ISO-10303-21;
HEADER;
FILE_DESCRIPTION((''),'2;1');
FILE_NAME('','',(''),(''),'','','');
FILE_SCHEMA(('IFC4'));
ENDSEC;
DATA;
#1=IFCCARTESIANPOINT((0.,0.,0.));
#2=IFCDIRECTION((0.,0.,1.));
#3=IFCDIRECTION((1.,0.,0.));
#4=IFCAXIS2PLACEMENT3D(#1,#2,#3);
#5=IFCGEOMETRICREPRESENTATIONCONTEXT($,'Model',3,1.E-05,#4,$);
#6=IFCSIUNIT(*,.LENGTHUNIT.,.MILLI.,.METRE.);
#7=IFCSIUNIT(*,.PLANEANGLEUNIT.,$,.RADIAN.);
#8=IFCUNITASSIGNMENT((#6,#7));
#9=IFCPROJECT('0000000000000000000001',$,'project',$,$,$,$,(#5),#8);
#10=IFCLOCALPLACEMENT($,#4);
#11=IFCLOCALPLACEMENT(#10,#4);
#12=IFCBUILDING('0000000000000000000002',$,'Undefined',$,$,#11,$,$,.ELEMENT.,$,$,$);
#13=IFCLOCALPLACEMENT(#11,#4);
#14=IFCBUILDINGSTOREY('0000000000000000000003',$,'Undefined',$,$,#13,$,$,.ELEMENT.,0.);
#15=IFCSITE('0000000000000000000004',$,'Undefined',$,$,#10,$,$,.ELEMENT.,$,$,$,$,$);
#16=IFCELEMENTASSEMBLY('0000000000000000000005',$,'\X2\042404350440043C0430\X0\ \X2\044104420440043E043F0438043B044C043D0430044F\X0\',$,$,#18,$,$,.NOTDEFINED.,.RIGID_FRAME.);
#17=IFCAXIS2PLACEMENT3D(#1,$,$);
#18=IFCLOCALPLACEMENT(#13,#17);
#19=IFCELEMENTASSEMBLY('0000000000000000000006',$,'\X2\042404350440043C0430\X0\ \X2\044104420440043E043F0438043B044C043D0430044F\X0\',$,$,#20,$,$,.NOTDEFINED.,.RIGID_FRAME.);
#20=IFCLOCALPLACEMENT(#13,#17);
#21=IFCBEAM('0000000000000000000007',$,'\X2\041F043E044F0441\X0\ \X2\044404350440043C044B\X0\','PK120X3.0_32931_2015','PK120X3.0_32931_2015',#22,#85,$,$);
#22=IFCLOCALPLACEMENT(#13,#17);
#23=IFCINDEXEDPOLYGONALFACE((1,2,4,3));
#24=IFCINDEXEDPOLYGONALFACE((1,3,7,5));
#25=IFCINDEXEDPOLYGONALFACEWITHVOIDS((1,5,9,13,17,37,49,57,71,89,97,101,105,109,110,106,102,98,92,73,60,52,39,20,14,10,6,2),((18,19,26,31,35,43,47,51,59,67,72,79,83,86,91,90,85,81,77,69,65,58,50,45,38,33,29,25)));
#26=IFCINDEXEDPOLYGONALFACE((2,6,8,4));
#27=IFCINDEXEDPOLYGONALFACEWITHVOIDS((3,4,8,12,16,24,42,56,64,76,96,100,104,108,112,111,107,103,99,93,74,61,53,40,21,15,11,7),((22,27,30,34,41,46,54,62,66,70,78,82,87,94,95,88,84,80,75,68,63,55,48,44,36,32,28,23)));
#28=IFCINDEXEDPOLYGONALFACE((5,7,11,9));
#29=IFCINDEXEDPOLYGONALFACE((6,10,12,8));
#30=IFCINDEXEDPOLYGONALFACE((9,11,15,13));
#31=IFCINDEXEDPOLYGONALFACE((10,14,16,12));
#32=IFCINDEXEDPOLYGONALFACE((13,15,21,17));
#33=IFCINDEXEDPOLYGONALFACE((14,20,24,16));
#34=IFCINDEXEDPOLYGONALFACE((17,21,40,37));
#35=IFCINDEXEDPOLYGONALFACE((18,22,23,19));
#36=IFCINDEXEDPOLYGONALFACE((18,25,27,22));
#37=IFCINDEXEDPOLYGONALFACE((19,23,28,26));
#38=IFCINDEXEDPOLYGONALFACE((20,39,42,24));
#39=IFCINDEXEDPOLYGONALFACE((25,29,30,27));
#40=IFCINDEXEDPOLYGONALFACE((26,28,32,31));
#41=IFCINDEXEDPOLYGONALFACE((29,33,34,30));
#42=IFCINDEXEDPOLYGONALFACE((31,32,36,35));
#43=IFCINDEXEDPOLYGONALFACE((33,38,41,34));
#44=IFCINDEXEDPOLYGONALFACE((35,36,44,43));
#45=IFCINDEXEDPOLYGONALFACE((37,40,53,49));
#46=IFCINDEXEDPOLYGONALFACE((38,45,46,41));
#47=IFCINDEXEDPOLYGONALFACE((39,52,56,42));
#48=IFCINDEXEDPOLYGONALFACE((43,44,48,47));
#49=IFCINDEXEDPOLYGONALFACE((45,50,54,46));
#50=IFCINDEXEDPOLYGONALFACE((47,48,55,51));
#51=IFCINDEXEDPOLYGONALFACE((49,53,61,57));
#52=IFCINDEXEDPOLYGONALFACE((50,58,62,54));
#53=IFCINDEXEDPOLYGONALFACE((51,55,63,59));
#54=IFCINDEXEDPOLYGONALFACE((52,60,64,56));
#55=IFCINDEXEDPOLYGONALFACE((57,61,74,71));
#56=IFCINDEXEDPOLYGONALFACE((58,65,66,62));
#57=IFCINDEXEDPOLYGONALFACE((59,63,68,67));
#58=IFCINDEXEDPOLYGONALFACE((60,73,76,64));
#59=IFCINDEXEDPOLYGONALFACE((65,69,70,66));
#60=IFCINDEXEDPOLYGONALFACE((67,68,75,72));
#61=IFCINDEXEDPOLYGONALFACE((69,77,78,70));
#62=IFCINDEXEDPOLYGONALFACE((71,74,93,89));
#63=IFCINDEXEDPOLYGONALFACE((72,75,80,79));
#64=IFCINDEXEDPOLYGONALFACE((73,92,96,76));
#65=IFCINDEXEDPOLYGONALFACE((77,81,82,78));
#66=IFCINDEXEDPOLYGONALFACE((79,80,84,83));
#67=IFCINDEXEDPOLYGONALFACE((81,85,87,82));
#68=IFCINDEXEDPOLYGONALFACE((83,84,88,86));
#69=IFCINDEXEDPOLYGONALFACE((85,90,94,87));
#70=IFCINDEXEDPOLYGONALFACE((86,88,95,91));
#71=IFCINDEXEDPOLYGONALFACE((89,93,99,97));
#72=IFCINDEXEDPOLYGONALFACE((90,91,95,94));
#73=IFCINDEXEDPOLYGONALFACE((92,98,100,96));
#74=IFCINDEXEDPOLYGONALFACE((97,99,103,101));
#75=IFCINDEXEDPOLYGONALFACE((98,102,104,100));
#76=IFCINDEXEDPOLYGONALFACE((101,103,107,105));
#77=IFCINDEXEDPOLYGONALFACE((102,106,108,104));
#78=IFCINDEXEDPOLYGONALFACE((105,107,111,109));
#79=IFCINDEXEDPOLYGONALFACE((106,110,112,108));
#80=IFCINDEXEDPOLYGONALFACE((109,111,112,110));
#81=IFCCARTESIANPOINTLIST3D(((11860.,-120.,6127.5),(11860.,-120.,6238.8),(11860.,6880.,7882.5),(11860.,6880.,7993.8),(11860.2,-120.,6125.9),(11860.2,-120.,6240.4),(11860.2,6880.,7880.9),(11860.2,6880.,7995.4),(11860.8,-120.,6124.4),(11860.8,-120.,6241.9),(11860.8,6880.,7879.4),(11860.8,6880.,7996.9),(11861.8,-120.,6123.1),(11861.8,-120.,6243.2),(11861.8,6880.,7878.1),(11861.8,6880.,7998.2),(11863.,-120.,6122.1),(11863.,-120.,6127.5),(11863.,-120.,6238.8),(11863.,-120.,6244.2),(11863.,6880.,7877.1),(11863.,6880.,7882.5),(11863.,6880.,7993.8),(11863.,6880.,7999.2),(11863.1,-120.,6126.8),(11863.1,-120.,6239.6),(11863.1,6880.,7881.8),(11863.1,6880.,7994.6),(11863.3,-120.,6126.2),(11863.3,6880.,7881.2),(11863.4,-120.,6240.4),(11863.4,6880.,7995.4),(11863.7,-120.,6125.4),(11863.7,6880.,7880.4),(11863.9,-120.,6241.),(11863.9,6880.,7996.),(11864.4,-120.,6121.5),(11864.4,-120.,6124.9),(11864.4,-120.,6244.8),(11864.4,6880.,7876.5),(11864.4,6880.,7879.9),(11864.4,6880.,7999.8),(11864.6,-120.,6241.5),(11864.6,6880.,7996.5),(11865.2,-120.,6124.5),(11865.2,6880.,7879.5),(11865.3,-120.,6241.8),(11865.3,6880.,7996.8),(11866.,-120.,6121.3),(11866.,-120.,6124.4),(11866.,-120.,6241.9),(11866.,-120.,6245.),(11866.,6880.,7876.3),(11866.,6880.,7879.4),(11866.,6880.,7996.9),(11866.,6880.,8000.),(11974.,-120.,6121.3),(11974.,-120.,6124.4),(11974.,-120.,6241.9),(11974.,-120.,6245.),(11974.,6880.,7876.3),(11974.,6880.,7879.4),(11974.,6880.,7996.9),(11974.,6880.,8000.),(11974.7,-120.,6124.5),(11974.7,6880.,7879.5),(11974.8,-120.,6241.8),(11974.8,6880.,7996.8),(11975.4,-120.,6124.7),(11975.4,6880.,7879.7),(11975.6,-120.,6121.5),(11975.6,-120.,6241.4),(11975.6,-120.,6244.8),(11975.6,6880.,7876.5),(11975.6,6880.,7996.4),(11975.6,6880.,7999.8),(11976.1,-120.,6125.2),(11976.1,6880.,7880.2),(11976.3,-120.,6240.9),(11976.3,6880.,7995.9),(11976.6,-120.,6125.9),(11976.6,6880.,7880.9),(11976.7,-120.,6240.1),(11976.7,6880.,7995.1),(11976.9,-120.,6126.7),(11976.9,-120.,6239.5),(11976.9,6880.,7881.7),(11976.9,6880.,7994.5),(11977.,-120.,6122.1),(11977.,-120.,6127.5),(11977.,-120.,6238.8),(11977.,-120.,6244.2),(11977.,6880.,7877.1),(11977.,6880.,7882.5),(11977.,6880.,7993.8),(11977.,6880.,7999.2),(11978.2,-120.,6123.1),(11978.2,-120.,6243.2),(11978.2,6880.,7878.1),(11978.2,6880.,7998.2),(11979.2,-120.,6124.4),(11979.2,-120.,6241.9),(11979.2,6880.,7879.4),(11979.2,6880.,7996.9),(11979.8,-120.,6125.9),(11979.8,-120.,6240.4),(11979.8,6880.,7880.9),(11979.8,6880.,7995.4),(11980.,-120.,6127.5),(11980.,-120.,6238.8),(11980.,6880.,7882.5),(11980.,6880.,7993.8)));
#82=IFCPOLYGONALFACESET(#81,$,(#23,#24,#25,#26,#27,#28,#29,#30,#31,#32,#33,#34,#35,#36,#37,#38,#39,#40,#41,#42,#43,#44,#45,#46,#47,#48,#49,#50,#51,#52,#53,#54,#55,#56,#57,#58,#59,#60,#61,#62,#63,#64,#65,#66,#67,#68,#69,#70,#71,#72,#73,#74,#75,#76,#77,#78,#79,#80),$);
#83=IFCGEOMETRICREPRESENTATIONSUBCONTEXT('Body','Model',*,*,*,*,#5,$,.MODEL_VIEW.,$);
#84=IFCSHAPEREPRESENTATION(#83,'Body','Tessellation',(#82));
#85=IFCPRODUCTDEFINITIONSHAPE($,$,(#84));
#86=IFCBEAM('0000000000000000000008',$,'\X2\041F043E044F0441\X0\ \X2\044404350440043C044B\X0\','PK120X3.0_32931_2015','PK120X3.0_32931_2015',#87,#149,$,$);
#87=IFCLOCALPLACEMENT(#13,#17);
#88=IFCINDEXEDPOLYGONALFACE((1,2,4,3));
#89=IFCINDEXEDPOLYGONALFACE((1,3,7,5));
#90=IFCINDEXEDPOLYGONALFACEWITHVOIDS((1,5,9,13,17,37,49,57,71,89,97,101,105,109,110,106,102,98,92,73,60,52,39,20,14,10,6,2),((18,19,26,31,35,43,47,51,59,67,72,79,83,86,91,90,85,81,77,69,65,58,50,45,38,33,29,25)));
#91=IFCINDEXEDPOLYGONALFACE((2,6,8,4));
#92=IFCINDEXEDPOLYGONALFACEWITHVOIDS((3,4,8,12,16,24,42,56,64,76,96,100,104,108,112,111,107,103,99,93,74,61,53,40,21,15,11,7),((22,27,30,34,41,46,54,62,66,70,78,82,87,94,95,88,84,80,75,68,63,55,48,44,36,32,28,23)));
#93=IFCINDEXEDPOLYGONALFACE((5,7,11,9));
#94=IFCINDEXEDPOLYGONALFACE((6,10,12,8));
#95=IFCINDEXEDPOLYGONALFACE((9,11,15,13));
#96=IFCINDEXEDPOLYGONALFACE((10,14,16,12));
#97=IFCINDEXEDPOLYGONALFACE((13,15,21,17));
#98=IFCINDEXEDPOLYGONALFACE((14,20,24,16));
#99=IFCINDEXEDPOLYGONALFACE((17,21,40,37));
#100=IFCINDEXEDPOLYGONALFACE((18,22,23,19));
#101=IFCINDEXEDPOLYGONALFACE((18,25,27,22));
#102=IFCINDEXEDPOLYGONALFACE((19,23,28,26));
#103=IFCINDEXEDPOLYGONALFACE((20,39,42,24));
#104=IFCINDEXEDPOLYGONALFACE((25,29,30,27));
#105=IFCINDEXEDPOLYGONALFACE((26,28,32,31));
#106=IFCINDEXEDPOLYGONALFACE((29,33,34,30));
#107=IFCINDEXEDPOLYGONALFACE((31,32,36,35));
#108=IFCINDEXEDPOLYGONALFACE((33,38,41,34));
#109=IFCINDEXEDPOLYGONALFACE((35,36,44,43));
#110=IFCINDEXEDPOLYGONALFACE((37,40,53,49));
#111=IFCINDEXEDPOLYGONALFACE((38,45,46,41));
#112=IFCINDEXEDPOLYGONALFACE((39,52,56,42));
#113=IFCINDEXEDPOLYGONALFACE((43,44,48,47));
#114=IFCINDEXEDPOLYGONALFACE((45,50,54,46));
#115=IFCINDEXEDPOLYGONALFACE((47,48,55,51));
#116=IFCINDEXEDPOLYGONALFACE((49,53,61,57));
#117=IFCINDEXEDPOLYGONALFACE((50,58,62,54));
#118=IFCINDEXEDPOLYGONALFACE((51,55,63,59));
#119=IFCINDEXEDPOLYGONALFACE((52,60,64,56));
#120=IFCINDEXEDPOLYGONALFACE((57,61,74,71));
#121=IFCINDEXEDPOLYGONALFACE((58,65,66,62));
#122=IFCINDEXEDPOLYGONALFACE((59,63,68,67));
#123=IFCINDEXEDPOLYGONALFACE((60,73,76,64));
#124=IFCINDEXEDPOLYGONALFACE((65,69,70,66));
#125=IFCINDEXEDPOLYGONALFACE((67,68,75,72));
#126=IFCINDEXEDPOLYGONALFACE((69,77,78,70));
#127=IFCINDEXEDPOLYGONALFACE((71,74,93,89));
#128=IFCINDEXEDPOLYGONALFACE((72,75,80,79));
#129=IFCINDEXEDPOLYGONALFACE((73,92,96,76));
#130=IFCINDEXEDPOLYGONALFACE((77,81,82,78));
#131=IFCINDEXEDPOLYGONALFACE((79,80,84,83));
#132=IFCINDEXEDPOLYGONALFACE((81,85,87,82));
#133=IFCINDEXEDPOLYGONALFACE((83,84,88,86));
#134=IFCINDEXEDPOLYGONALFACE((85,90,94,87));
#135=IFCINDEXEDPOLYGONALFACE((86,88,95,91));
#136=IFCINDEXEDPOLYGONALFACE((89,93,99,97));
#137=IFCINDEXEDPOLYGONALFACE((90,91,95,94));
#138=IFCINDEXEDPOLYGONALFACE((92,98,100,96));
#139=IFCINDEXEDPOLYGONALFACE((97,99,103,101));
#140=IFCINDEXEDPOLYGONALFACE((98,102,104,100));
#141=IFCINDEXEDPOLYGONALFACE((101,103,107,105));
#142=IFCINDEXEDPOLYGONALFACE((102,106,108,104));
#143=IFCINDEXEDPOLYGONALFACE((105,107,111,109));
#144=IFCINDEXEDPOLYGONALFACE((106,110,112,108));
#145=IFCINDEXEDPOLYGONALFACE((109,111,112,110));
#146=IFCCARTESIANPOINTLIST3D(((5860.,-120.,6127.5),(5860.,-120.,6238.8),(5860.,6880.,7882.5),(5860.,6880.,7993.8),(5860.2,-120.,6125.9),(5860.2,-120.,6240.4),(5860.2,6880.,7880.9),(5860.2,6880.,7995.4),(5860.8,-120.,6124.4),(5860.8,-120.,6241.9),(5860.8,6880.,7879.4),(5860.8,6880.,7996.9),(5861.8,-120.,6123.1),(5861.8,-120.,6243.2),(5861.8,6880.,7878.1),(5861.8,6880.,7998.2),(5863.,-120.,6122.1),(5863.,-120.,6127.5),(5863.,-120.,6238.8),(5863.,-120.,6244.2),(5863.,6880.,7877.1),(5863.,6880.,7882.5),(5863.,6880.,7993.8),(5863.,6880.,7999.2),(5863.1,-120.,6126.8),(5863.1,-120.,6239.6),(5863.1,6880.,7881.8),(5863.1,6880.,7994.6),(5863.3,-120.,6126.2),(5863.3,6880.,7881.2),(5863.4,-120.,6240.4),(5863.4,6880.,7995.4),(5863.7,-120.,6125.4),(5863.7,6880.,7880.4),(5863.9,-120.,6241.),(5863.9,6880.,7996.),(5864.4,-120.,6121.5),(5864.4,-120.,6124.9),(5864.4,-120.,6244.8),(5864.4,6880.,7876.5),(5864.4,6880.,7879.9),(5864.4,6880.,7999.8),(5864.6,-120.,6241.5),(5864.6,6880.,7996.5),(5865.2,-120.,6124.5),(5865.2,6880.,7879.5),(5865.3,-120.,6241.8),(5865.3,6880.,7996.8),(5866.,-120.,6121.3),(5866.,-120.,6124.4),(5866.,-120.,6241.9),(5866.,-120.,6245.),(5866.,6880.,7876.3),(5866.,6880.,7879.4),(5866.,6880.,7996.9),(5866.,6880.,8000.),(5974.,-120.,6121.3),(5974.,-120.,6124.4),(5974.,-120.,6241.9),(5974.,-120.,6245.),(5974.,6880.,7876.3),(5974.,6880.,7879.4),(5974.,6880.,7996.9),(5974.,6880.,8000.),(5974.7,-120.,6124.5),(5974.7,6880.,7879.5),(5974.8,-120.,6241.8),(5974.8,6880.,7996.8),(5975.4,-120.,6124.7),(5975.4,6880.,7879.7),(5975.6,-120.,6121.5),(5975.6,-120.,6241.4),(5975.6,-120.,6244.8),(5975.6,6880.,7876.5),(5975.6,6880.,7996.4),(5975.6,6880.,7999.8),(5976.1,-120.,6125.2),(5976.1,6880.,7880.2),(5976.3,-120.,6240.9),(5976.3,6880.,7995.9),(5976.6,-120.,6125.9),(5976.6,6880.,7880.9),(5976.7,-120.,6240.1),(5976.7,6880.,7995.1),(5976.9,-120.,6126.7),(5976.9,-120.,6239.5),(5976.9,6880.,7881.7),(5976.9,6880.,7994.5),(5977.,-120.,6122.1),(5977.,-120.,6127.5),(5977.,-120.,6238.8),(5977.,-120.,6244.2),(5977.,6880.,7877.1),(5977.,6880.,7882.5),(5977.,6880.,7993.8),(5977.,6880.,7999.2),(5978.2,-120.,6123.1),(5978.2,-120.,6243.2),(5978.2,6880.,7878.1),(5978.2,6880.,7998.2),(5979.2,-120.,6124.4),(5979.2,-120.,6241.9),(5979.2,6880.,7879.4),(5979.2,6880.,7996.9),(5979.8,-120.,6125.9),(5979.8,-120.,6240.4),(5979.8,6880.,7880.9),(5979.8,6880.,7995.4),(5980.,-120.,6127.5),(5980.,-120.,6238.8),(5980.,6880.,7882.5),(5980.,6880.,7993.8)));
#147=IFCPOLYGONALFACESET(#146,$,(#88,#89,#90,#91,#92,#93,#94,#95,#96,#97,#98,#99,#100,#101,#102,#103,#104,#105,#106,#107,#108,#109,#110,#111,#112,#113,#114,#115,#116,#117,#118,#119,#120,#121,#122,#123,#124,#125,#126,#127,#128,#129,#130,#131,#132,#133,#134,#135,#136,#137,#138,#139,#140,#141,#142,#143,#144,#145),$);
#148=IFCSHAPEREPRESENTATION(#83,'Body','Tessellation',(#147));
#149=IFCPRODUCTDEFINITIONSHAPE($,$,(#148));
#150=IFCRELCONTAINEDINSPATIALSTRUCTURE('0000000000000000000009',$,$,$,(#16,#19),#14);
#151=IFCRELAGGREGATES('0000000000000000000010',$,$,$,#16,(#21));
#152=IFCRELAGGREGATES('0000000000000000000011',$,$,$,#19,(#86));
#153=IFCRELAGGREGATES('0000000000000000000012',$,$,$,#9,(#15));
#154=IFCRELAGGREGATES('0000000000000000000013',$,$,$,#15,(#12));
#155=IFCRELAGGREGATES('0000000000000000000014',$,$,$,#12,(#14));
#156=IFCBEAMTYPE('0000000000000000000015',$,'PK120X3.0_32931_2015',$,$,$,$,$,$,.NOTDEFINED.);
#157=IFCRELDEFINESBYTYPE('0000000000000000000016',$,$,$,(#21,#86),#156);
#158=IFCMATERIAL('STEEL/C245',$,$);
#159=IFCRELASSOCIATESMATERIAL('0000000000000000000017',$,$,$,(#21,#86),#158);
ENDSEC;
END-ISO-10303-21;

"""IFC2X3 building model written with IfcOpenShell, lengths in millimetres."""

from ifc_helpers import new_model, si_unit, frame, origin_with_axes, origin_2d_with_axis, place, context, subcontext, project, spatial, hollow_rectangle, extrude, clip, halfspace, material, type_object, element, aggregate, save


model = new_model("IFC2X3")

# Units and contexts
model_context = context("Model", 3, precision=1e-05, world=origin_with_axes())
body_context = subcontext(model_context, "Body", "Model", "MODEL_VIEW")
ifc_project = project(units=[si_unit("LENGTHUNIT", "METRE", prefix="MILLI"), si_unit("PLANEANGLEUNIT", "RADIAN")], contexts=[model_context])

# Site, building, storey
site_placement = place(None, origin_with_axes())
site = spatial("IfcSite", under=ifc_project, at=site_placement, Name="Undefined", CompositionType="ELEMENT")
building_placement = place(site_placement, origin_with_axes())
building = spatial("IfcBuilding", under=site, at=building_placement, Name="Undefined", CompositionType="ELEMENT")
storey_placement = place(building_placement, origin_with_axes())
storey = spatial("IfcBuildingStorey", under=building, at=storey_placement, Name="Undefined", CompositionType="ELEMENT", Elevation=0.0)

# Shared definitions
ifc_material = material(Name="STEEL/C245")

# Element assemblies
assembly_1_placement = place(storey_placement, origin_with_axes())
assembly_1 = element("IfcElementAssembly", 1, at=assembly_1_placement, inside=storey, Name="Ферма стропильная", AssemblyPlace="NOTDEFINED", PredefinedType="RIGID_FRAME")
assembly_2_placement = place(storey_placement, origin_with_axes())
assembly_2 = element("IfcElementAssembly", 2, at=assembly_2_placement, inside=storey, Name="Ферма стропильная", AssemblyPlace="NOTDEFINED", PredefinedType="RIGID_FRAME")

# Beams
beam_type_1 = type_object("IfcBeamType", Name="PK120X3.0_32931_2015", PredefinedType="NOTDEFINED")
beam_1_placement = place(assembly_1_placement, frame((11920.0, -105.4, 6186.8), z_axis=(0.0, -0.243188, 0.969979), x_axis=(0.0, 0.969979, 0.243188)))
beam_1 = element("IfcBeam", 3, at=beam_1_placement, type_object=beam_type_1, material=ifc_material, Name="Пояс фермы", Description="PK120X3.0_32931_2015", ObjectType="PK120X3.0_32931_2015", context=body_context, shape_type="Clipping", body=[
    clip(clip(extrude(hollow_rectangle(XDim=120.0, YDim=120.0, WallThickness=3.0, InnerFilletRadius=3.0, OuterFilletRadius=6.0, at=origin_2d_with_axis()), frame((7232.0, 0.0, 0.0), z_axis=(-1.0, 0.0, 0.0), x_axis=(0.0, -1.0, 0.0)), (0.0, 0.0, 1.0), 7277.4), halfspace(frame((7216.6, 0.0, 60.0), z_axis=(0.969979, 0.0, -0.243188), x_axis=(0.0, -1.0, 0.0)), False)), halfspace(frame((0.0, 0.0, 60.0), z_axis=(0.969979, 0.0, -0.243188), x_axis=(0.0, -1.0, 0.0)), True)),
])
aggregate(assembly_1, [beam_1])
beam_2_placement = place(assembly_2_placement, frame((5920.0, -105.4, 6186.8), z_axis=(0.0, -0.243188, 0.969979), x_axis=(0.0, 0.969979, 0.243188)))
beam_2 = element("IfcBeam", 4, at=beam_2_placement, type_object=beam_type_1, material=ifc_material, Name="Пояс фермы", Description="PK120X3.0_32931_2015", ObjectType="PK120X3.0_32931_2015", context=body_context, shape_type="Clipping", body=[
    clip(clip(extrude(hollow_rectangle(XDim=120.0, YDim=120.0, WallThickness=3.0, InnerFilletRadius=3.0, OuterFilletRadius=6.0, at=origin_2d_with_axis()), frame((7232.0, 0.0, 0.0), z_axis=(-1.0, 0.0, 0.0), x_axis=(0.0, -1.0, 0.0)), (0.0, 0.0, 1.0), 7277.4), halfspace(frame((7216.6, 0.0, 60.0), z_axis=(0.969979, 0.0, -0.243188), x_axis=(0.0, -1.0, 0.0)), False)), halfspace(frame((0.0, 0.0, 60.0), z_axis=(0.969979, 0.0, -0.243188), x_axis=(0.0, -1.0, 0.0)), True)),
])
aggregate(assembly_2, [beam_2])

save(model, "model.ifc")
